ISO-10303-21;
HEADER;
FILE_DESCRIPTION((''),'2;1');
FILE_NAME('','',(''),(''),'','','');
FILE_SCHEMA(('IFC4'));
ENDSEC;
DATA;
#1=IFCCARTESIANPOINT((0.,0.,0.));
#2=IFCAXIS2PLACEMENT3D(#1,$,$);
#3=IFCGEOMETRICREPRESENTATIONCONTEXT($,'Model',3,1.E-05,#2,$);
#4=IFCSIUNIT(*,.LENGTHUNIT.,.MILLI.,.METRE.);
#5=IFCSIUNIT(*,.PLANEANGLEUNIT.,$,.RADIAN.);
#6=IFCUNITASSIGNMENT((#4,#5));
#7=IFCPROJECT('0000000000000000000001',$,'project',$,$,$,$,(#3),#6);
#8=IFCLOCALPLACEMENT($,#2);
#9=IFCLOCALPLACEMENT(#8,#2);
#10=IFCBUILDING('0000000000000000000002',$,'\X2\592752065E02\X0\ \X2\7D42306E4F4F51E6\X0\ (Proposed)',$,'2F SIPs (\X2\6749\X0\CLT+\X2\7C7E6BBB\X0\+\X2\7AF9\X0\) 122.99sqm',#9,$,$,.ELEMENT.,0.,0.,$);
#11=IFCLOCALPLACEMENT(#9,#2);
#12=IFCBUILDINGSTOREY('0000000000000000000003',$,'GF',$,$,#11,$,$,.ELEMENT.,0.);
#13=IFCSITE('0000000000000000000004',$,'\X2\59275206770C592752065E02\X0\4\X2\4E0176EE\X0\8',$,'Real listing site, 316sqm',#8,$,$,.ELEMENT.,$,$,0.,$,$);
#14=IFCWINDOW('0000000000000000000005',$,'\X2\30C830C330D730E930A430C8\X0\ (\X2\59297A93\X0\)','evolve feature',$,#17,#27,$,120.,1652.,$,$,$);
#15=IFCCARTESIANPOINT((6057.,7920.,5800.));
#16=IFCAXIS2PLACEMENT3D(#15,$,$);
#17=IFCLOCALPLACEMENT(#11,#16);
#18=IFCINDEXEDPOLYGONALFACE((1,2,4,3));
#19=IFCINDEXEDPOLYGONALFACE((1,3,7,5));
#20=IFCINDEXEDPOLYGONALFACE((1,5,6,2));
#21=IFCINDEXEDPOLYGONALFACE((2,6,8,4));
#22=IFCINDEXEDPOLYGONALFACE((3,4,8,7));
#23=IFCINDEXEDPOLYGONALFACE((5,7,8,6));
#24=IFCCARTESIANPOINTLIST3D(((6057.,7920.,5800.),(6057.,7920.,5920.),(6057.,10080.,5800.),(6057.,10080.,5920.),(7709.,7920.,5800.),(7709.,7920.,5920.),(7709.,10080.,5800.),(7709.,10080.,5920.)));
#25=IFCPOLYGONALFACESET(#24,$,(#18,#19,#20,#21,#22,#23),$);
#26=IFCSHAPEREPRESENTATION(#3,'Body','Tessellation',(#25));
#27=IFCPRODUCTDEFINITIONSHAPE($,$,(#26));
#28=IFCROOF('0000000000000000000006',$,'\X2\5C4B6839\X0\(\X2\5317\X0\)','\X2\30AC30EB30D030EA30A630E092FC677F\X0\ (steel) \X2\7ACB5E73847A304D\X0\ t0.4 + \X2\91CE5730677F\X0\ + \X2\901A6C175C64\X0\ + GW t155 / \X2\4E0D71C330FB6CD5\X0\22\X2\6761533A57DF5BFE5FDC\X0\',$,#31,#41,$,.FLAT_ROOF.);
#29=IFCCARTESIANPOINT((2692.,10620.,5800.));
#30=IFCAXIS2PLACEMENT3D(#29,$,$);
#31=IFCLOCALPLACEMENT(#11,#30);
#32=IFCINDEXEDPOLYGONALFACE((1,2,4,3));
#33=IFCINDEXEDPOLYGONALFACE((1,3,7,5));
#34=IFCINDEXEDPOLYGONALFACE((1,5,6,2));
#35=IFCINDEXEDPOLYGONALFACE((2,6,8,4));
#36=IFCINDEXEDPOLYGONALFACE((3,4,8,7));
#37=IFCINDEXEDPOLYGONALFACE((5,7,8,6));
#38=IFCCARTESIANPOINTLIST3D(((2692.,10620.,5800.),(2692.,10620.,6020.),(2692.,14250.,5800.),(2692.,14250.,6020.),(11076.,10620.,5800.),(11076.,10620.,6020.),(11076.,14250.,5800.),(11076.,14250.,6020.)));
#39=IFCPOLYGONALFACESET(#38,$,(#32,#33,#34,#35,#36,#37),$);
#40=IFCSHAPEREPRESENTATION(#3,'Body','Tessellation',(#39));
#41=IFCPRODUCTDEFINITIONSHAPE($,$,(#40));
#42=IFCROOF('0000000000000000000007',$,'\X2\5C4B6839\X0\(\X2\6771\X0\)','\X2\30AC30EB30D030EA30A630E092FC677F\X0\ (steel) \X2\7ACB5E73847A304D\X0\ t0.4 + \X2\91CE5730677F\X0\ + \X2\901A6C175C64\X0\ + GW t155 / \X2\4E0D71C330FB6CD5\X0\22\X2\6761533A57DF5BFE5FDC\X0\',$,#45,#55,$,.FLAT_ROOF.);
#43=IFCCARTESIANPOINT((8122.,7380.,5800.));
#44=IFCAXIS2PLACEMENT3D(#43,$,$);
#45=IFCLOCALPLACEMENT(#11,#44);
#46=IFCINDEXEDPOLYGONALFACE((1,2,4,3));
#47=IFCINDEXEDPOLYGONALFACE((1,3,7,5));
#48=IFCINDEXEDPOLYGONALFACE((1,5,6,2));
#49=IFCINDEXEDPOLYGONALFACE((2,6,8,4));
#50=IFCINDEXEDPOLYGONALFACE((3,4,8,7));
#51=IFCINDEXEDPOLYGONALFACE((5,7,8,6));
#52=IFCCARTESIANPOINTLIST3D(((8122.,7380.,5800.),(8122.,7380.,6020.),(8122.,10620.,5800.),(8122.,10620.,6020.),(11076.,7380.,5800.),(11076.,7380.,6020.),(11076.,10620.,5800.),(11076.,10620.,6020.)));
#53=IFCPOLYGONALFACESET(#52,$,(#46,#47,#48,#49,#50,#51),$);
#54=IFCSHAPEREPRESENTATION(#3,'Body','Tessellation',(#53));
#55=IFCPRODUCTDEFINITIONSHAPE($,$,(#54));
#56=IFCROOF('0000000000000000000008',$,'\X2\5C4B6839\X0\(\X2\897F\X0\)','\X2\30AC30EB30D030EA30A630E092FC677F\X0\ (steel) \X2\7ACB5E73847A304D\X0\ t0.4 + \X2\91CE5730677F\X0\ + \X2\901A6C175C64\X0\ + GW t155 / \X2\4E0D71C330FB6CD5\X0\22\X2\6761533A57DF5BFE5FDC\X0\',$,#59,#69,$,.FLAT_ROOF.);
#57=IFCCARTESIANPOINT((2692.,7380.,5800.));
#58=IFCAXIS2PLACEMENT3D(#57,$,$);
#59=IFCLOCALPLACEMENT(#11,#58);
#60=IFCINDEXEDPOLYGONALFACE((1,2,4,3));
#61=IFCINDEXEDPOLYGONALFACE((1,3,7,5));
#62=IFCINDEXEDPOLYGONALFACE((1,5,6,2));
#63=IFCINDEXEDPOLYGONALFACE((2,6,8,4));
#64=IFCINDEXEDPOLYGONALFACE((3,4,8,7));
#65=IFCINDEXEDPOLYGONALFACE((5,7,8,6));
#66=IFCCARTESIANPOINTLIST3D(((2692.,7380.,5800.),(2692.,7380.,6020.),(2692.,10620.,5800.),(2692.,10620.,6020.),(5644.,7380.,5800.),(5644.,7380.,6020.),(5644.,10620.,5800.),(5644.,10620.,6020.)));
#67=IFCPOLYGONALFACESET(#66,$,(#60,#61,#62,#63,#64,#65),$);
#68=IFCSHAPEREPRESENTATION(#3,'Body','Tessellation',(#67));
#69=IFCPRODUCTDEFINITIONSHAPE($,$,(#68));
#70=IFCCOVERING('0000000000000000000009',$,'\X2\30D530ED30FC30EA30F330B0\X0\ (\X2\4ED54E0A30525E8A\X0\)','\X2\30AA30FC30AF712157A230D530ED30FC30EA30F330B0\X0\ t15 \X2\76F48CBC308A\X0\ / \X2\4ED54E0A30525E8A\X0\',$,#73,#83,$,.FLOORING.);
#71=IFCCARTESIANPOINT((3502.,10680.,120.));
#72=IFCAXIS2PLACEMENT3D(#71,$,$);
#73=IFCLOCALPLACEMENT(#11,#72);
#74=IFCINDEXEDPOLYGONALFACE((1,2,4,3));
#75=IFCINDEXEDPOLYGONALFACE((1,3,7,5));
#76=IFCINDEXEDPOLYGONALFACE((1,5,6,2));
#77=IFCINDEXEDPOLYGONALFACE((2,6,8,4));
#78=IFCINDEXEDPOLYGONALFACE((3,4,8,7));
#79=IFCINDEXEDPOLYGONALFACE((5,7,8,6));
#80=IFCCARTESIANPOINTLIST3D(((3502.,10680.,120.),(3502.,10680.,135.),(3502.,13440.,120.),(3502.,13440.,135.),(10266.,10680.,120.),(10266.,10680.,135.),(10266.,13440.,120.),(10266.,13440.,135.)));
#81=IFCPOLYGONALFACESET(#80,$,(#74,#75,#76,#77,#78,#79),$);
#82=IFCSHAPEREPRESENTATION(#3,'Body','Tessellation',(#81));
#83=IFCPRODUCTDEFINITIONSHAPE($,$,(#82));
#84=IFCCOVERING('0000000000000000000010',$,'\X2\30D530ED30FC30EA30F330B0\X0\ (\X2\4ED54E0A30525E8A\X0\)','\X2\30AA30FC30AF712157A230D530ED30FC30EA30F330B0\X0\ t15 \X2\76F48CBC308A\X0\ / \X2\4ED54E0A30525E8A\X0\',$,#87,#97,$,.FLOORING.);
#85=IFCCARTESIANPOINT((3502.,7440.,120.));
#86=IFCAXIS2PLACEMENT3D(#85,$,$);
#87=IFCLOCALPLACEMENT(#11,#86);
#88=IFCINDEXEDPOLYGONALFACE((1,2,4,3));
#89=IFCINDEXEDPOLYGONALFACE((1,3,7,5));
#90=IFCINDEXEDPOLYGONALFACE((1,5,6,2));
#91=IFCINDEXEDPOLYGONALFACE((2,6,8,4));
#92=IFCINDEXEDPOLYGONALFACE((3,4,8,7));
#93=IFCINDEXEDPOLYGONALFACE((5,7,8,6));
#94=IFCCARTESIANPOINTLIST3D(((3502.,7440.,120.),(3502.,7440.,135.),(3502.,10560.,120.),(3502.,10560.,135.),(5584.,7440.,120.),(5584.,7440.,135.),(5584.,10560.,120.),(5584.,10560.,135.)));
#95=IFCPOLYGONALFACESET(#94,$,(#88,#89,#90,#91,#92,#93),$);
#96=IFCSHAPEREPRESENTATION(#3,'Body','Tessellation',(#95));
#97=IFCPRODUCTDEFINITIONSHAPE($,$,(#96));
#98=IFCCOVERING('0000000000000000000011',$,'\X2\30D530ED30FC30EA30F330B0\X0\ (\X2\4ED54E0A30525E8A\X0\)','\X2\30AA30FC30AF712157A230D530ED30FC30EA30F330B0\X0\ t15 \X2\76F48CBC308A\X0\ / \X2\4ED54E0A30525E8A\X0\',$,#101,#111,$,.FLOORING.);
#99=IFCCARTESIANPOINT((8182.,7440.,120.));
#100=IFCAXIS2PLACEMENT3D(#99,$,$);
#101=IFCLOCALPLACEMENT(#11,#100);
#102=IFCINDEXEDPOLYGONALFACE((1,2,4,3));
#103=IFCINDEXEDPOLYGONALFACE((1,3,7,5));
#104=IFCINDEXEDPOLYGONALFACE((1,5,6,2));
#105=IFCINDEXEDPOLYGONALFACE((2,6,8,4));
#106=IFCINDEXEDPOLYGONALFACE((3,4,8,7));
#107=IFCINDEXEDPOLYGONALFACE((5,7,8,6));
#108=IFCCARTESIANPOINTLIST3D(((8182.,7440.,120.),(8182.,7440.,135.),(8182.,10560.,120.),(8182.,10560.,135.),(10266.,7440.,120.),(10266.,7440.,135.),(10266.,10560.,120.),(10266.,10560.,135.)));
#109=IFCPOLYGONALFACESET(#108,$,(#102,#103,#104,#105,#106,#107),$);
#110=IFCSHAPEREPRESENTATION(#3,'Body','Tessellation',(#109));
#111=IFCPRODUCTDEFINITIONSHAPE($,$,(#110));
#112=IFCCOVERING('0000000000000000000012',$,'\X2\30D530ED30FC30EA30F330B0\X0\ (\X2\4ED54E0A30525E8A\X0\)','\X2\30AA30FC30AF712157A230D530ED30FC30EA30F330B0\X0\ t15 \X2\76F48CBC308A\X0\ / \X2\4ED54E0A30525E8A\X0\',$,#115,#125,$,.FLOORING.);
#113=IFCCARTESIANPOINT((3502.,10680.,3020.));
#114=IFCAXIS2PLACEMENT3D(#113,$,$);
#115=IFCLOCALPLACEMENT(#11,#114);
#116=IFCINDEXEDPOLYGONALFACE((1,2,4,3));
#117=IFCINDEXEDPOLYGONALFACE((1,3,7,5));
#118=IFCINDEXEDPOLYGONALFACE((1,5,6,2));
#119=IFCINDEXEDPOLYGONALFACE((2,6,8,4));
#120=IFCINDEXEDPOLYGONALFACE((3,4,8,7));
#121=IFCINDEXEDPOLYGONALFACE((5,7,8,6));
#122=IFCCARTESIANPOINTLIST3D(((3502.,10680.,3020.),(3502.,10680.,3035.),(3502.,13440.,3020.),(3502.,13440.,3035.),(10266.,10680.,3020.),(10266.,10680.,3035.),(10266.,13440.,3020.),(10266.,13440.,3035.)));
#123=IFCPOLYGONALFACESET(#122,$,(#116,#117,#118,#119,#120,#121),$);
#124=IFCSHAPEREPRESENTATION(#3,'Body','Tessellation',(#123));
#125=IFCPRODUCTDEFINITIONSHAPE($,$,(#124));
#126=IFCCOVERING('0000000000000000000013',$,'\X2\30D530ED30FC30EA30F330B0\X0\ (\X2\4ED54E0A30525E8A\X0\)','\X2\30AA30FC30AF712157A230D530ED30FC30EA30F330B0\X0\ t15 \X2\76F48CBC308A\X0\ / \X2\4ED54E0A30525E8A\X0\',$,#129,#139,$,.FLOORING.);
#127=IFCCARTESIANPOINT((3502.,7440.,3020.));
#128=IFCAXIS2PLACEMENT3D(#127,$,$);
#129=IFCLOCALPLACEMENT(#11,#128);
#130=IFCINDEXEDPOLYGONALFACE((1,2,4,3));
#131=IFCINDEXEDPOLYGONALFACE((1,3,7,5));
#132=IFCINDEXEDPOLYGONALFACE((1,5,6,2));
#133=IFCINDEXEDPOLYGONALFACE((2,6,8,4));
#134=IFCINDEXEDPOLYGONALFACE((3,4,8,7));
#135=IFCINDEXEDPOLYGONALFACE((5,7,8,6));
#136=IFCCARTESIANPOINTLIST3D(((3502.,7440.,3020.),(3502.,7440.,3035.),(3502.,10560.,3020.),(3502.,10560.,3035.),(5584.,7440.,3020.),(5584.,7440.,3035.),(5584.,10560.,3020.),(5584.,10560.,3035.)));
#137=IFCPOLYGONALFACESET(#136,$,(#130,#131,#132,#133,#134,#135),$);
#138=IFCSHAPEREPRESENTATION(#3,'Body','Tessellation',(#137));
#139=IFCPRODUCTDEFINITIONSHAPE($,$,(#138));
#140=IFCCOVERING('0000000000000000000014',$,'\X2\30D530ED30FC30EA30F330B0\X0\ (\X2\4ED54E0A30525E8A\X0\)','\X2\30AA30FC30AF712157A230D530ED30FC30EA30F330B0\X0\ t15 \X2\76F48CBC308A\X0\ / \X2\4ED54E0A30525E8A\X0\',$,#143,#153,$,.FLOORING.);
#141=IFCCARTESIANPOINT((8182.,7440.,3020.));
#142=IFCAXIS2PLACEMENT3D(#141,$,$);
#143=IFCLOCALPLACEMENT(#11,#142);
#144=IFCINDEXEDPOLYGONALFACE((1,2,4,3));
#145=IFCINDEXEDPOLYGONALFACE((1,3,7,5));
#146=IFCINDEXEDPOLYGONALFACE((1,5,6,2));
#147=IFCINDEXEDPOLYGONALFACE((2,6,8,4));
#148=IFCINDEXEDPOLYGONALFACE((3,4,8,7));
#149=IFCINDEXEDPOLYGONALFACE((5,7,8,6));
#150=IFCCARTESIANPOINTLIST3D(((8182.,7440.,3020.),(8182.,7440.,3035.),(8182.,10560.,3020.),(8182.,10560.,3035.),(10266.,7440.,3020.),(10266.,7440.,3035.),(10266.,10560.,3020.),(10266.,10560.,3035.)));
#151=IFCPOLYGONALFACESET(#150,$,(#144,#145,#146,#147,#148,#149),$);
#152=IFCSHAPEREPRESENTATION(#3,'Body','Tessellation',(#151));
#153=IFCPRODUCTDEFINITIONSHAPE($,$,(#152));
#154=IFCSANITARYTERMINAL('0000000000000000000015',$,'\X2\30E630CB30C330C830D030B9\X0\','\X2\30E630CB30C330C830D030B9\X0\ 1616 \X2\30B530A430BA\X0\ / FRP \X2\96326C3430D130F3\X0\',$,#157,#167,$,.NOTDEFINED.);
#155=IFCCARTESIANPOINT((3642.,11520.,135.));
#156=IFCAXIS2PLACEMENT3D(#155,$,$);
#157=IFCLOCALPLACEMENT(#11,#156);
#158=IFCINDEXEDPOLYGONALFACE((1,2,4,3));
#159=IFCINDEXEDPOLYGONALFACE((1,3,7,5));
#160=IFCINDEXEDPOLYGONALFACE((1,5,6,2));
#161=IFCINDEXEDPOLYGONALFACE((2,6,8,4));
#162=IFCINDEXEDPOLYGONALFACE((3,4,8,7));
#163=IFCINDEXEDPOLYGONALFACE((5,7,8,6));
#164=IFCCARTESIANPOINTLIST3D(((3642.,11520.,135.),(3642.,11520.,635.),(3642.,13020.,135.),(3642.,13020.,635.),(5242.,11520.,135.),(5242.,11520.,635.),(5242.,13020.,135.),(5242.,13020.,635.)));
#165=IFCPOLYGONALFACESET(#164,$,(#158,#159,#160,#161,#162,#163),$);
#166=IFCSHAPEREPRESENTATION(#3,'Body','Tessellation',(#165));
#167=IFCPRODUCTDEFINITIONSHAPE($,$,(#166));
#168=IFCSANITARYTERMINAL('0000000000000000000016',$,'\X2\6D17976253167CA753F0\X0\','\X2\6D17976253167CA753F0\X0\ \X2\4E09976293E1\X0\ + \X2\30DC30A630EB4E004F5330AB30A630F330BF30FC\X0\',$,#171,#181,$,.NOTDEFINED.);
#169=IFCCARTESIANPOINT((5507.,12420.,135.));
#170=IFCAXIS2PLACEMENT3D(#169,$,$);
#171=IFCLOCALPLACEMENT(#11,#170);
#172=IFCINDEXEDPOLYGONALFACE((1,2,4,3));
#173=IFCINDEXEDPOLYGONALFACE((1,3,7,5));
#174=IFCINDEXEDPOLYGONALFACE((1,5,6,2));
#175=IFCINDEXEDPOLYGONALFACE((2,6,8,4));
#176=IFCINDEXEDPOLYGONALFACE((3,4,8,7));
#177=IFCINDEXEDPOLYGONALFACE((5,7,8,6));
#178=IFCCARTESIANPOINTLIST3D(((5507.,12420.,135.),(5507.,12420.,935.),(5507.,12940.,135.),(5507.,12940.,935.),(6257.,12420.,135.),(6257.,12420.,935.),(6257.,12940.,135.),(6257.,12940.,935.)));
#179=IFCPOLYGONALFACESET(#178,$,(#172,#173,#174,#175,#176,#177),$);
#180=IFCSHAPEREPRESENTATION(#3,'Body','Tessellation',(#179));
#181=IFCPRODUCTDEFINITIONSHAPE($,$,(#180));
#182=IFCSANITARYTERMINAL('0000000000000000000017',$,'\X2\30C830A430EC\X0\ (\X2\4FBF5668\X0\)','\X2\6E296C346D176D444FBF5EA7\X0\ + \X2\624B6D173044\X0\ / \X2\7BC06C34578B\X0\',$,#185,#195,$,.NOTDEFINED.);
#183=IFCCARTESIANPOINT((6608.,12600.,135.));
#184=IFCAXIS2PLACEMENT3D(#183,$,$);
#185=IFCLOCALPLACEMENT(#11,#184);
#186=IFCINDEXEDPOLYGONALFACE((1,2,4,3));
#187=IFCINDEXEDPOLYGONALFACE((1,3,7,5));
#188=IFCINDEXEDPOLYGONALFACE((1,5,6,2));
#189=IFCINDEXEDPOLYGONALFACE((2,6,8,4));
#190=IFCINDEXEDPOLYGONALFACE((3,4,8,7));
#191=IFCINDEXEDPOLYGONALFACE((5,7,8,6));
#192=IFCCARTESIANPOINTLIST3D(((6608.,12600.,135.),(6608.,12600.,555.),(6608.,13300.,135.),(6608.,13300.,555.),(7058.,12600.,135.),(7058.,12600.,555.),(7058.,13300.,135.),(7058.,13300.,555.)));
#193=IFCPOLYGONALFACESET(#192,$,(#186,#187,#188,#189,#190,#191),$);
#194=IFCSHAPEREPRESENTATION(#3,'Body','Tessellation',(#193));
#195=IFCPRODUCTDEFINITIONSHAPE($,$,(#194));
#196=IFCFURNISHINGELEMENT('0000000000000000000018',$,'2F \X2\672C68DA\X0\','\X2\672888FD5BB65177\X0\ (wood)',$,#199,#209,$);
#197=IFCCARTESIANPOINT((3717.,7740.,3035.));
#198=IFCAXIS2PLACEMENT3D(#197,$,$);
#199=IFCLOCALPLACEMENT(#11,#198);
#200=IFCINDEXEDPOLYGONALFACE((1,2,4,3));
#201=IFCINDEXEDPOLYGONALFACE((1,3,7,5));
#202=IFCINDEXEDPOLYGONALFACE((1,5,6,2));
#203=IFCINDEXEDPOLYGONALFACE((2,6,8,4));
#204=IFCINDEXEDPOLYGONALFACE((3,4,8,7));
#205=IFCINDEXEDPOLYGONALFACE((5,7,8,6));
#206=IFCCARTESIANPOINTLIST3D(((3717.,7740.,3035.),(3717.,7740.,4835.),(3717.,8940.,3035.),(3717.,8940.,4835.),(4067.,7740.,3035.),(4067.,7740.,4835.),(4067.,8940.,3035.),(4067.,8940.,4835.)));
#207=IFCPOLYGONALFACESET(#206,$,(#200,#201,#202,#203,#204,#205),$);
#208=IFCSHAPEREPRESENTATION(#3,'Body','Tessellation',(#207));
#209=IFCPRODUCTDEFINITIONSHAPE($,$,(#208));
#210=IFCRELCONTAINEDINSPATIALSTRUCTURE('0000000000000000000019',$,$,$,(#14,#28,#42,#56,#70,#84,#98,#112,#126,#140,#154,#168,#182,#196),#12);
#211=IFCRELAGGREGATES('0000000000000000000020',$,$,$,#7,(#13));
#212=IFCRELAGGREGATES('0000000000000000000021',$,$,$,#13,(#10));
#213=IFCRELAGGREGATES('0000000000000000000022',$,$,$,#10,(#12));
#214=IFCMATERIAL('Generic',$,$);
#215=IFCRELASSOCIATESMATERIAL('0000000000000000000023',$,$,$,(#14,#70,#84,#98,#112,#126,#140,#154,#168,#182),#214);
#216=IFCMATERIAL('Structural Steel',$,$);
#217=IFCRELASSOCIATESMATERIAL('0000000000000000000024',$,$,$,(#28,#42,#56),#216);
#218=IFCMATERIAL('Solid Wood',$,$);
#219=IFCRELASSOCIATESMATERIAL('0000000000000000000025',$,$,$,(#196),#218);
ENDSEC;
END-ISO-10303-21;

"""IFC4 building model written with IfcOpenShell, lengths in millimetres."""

from ifc_helpers import new_model, si_unit, frame, frame_2d, origin, place, context, project, spatial, rectangle, extrude, material, element, save


model = new_model("IFC4")

# Units and contexts
model_context = context("Model", 3, precision=1e-05, world=origin())
ifc_project = project(units=[si_unit("LENGTHUNIT", "METRE", prefix="MILLI"), si_unit("PLANEANGLEUNIT", "RADIAN")], contexts=[model_context])

# Site, building, storey
site_placement = place(None, origin())
site = spatial("IfcSite", under=ifc_project, at=site_placement, Name="大分県大分市4丁目8", ObjectType="Real listing site, 316sqm", CompositionType="ELEMENT", RefElevation=0.0)
building_placement = place(site_placement, origin())
building = spatial("IfcBuilding", under=site, at=building_placement, Name="大分市 終の住処 (Proposed)", ObjectType="2F SIPs (杉CLT+籾殻+竹) 122.99sqm", CompositionType="ELEMENT", ElevationOfRefHeight=0.0, ElevationOfTerrain=0.0)
storey_placement = place(building_placement, origin())
storey = spatial("IfcBuildingStorey", under=building, at=storey_placement, Name="GF", CompositionType="ELEMENT", Elevation=0.0)

# Shared definitions
ifc_material_1 = material(Name="Solid Wood")

# Window
ifc_material_2 = material(Name="Generic")
window_1_placement = place(storey_placement, frame((6057.0, 7920.0, 5800.0)))
element("IfcWindow", 1, at=window_1_placement, inside=storey, material=ifc_material_2, Name="トップライト (天窓)", Description="evolve feature", OverallHeight=120.0, OverallWidth=1652.0, context=model_context, shape_type="SweptSolid", body=[
    extrude(rectangle(XDim=1652.0, YDim=2160.0, at=frame_2d((826.0, 1080.0))), frame((6057.0, 7920.0, 5800.0)), (0.0, 0.0, 1.0), 120.0),
])

# Roofs
ifc_material_3 = material(Name="Structural Steel")
roof_1_placement = place(storey_placement, frame((2692.0, 10620.0, 5800.0)))
element("IfcRoof", 2, at=roof_1_placement, inside=storey, material=ifc_material_3, Name="屋根(北)", Description="ガルバリウム鋼板 (steel) 立平葺き t0.4 + 野地板 + 通気層 + GW t155 / 不燃・法22条区域対応", PredefinedType="FLAT_ROOF", context=model_context, shape_type="SweptSolid", body=[
    extrude(rectangle(XDim=8384.0, YDim=3630.0, at=frame_2d((4192.0, 1815.0))), frame((2692.0, 10620.0, 5800.0)), (0.0, 0.0, 1.0), 220.0),
])
roof_2_placement = place(storey_placement, frame((8122.0, 7380.0, 5800.0)))
element("IfcRoof", 3, at=roof_2_placement, inside=storey, material=ifc_material_3, Name="屋根(東)", Description="ガルバリウム鋼板 (steel) 立平葺き t0.4 + 野地板 + 通気層 + GW t155 / 不燃・法22条区域対応", PredefinedType="FLAT_ROOF", context=model_context, shape_type="SweptSolid", body=[
    extrude(rectangle(XDim=2954.0, YDim=3240.0, at=frame_2d((1477.0, 1620.0))), frame((8122.0, 7380.0, 5800.0)), (0.0, 0.0, 1.0), 220.0),
])
roof_3_placement = place(storey_placement, frame((2692.0, 7380.0, 5800.0)))
element("IfcRoof", 4, at=roof_3_placement, inside=storey, material=ifc_material_3, Name="屋根(西)", Description="ガルバリウム鋼板 (steel) 立平葺き t0.4 + 野地板 + 通気層 + GW t155 / 不燃・法22条区域対応", PredefinedType="FLAT_ROOF", context=model_context, shape_type="SweptSolid", body=[
    extrude(rectangle(XDim=2952.0, YDim=3240.0, at=frame_2d((1476.0, 1620.0))), frame((2692.0, 7380.0, 5800.0)), (0.0, 0.0, 1.0), 220.0),
])

# Coverings
covering_1_placement = place(storey_placement, frame((3502.0, 10680.0, 120.0)))
element("IfcCovering", 5, at=covering_1_placement, inside=storey, material=ifc_material_2, Name="フローリング (仕上げ床)", Description="オーク無垢フローリング t15 直貼り / 仕上げ床", PredefinedType="FLOORING", context=model_context, shape_type="SweptSolid", body=[
    extrude(rectangle(XDim=6764.0, YDim=2760.0, at=frame_2d((3382.0, 1380.0))), frame((3502.0, 10680.0, 120.0)), (0.0, 0.0, 1.0), 15.0),
])
covering_2_placement = place(storey_placement, frame((3502.0, 7440.0, 120.0)))
element("IfcCovering", 6, at=covering_2_placement, inside=storey, material=ifc_material_2, Name="フローリング (仕上げ床)", Description="オーク無垢フローリング t15 直貼り / 仕上げ床", PredefinedType="FLOORING", context=model_context, shape_type="SweptSolid", body=[
    extrude(rectangle(XDim=2082.0, YDim=3120.0, at=frame_2d((1041.0, 1560.0))), frame((3502.0, 7440.0, 120.0)), (0.0, 0.0, 1.0), 15.0),
])
covering_3_placement = place(storey_placement, frame((8182.0, 7440.0, 120.0)))
element("IfcCovering", 7, at=covering_3_placement, inside=storey, material=ifc_material_2, Name="フローリング (仕上げ床)", Description="オーク無垢フローリング t15 直貼り / 仕上げ床", PredefinedType="FLOORING", context=model_context, shape_type="SweptSolid", body=[
    extrude(rectangle(XDim=2084.0, YDim=3120.0, at=frame_2d((1042.0, 1560.0))), frame((8182.0, 7440.0, 120.0)), (0.0, 0.0, 1.0), 15.0),
])
covering_4_placement = place(storey_placement, frame((3502.0, 10680.0, 3020.0)))
element("IfcCovering", 8, at=covering_4_placement, inside=storey, material=ifc_material_2, Name="フローリング (仕上げ床)", Description="オーク無垢フローリング t15 直貼り / 仕上げ床", PredefinedType="FLOORING", context=model_context, shape_type="SweptSolid", body=[
    extrude(rectangle(XDim=6764.0, YDim=2760.0, at=frame_2d((3382.0, 1380.0))), frame((3502.0, 10680.0, 3020.0)), (0.0, 0.0, 1.0), 15.0),
])
covering_5_placement = place(storey_placement, frame((3502.0, 7440.0, 3020.0)))
element("IfcCovering", 9, at=covering_5_placement, inside=storey, material=ifc_material_2, Name="フローリング (仕上げ床)", Description="オーク無垢フローリング t15 直貼り / 仕上げ床", PredefinedType="FLOORING", context=model_context, shape_type="SweptSolid", body=[
    extrude(rectangle(XDim=2082.0, YDim=3120.0, at=frame_2d((1041.0, 1560.0))), frame((3502.0, 7440.0, 3020.0)), (0.0, 0.0, 1.0), 15.0),
])
covering_6_placement = place(storey_placement, frame((8182.0, 7440.0, 3020.0)))
element("IfcCovering", 10, at=covering_6_placement, inside=storey, material=ifc_material_2, Name="フローリング (仕上げ床)", Description="オーク無垢フローリング t15 直貼り / 仕上げ床", PredefinedType="FLOORING", context=model_context, shape_type="SweptSolid", body=[
    extrude(rectangle(XDim=2084.0, YDim=3120.0, at=frame_2d((1042.0, 1560.0))), frame((8182.0, 7440.0, 3020.0)), (0.0, 0.0, 1.0), 15.0),
])

# Sanitary terminals
sanitary_terminal_1_placement = place(storey_placement, frame((3642.0, 11520.0, 135.0)))
element("IfcSanitaryTerminal", 11, at=sanitary_terminal_1_placement, inside=storey, material=ifc_material_2, Name="ユニットバス", Description="ユニットバス 1616 サイズ / FRP 防水パン", PredefinedType="NOTDEFINED", context=model_context, shape_type="SweptSolid", body=[
    extrude(rectangle(XDim=1600.0, YDim=1500.0, at=frame_2d((800.0, 750.0))), frame((3642.0, 11520.0, 135.0)), (0.0, 0.0, 1.0), 500.0),
])
sanitary_terminal_2_placement = place(storey_placement, frame((5507.0, 12420.0, 135.0)))
element("IfcSanitaryTerminal", 12, at=sanitary_terminal_2_placement, inside=storey, material=ifc_material_2, Name="洗面化粧台", Description="洗面化粧台 三面鏡 + ボウル一体カウンター", PredefinedType="NOTDEFINED", context=model_context, shape_type="SweptSolid", body=[
    extrude(rectangle(XDim=750.0, YDim=520.0, at=frame_2d((375.0, 260.0))), frame((5507.0, 12420.0, 135.0)), (0.0, 0.0, 1.0), 800.0),
])
sanitary_terminal_3_placement = place(storey_placement, frame((6608.0, 12600.0, 135.0)))
element("IfcSanitaryTerminal", 13, at=sanitary_terminal_3_placement, inside=storey, material=ifc_material_2, Name="トイレ (便器)", Description="温水洗浄便座 + 手洗い / 節水型", PredefinedType="NOTDEFINED", context=model_context, shape_type="SweptSolid", body=[
    extrude(rectangle(XDim=450.0, YDim=700.0, at=frame_2d((225.0, 350.0))), frame((6608.0, 12600.0, 135.0)), (0.0, 0.0, 1.0), 420.0),
])

# Furnishing element
furnishing_placement = place(storey_placement, frame((3717.0, 7740.0, 3035.0)))
element("IfcFurnishingElement", 14, at=furnishing_placement, inside=storey, material=ifc_material_1, Name="2F 本棚", Description="木製家具 (wood)", context=model_context, shape_type="SweptSolid", body=[
    extrude(rectangle(XDim=350.0, YDim=1200.0, at=frame_2d((175.0, 600.0))), frame((3717.0, 7740.0, 3035.0)), (0.0, 0.0, 1.0), 1800.0),
])

save(model, "model.ifc")
